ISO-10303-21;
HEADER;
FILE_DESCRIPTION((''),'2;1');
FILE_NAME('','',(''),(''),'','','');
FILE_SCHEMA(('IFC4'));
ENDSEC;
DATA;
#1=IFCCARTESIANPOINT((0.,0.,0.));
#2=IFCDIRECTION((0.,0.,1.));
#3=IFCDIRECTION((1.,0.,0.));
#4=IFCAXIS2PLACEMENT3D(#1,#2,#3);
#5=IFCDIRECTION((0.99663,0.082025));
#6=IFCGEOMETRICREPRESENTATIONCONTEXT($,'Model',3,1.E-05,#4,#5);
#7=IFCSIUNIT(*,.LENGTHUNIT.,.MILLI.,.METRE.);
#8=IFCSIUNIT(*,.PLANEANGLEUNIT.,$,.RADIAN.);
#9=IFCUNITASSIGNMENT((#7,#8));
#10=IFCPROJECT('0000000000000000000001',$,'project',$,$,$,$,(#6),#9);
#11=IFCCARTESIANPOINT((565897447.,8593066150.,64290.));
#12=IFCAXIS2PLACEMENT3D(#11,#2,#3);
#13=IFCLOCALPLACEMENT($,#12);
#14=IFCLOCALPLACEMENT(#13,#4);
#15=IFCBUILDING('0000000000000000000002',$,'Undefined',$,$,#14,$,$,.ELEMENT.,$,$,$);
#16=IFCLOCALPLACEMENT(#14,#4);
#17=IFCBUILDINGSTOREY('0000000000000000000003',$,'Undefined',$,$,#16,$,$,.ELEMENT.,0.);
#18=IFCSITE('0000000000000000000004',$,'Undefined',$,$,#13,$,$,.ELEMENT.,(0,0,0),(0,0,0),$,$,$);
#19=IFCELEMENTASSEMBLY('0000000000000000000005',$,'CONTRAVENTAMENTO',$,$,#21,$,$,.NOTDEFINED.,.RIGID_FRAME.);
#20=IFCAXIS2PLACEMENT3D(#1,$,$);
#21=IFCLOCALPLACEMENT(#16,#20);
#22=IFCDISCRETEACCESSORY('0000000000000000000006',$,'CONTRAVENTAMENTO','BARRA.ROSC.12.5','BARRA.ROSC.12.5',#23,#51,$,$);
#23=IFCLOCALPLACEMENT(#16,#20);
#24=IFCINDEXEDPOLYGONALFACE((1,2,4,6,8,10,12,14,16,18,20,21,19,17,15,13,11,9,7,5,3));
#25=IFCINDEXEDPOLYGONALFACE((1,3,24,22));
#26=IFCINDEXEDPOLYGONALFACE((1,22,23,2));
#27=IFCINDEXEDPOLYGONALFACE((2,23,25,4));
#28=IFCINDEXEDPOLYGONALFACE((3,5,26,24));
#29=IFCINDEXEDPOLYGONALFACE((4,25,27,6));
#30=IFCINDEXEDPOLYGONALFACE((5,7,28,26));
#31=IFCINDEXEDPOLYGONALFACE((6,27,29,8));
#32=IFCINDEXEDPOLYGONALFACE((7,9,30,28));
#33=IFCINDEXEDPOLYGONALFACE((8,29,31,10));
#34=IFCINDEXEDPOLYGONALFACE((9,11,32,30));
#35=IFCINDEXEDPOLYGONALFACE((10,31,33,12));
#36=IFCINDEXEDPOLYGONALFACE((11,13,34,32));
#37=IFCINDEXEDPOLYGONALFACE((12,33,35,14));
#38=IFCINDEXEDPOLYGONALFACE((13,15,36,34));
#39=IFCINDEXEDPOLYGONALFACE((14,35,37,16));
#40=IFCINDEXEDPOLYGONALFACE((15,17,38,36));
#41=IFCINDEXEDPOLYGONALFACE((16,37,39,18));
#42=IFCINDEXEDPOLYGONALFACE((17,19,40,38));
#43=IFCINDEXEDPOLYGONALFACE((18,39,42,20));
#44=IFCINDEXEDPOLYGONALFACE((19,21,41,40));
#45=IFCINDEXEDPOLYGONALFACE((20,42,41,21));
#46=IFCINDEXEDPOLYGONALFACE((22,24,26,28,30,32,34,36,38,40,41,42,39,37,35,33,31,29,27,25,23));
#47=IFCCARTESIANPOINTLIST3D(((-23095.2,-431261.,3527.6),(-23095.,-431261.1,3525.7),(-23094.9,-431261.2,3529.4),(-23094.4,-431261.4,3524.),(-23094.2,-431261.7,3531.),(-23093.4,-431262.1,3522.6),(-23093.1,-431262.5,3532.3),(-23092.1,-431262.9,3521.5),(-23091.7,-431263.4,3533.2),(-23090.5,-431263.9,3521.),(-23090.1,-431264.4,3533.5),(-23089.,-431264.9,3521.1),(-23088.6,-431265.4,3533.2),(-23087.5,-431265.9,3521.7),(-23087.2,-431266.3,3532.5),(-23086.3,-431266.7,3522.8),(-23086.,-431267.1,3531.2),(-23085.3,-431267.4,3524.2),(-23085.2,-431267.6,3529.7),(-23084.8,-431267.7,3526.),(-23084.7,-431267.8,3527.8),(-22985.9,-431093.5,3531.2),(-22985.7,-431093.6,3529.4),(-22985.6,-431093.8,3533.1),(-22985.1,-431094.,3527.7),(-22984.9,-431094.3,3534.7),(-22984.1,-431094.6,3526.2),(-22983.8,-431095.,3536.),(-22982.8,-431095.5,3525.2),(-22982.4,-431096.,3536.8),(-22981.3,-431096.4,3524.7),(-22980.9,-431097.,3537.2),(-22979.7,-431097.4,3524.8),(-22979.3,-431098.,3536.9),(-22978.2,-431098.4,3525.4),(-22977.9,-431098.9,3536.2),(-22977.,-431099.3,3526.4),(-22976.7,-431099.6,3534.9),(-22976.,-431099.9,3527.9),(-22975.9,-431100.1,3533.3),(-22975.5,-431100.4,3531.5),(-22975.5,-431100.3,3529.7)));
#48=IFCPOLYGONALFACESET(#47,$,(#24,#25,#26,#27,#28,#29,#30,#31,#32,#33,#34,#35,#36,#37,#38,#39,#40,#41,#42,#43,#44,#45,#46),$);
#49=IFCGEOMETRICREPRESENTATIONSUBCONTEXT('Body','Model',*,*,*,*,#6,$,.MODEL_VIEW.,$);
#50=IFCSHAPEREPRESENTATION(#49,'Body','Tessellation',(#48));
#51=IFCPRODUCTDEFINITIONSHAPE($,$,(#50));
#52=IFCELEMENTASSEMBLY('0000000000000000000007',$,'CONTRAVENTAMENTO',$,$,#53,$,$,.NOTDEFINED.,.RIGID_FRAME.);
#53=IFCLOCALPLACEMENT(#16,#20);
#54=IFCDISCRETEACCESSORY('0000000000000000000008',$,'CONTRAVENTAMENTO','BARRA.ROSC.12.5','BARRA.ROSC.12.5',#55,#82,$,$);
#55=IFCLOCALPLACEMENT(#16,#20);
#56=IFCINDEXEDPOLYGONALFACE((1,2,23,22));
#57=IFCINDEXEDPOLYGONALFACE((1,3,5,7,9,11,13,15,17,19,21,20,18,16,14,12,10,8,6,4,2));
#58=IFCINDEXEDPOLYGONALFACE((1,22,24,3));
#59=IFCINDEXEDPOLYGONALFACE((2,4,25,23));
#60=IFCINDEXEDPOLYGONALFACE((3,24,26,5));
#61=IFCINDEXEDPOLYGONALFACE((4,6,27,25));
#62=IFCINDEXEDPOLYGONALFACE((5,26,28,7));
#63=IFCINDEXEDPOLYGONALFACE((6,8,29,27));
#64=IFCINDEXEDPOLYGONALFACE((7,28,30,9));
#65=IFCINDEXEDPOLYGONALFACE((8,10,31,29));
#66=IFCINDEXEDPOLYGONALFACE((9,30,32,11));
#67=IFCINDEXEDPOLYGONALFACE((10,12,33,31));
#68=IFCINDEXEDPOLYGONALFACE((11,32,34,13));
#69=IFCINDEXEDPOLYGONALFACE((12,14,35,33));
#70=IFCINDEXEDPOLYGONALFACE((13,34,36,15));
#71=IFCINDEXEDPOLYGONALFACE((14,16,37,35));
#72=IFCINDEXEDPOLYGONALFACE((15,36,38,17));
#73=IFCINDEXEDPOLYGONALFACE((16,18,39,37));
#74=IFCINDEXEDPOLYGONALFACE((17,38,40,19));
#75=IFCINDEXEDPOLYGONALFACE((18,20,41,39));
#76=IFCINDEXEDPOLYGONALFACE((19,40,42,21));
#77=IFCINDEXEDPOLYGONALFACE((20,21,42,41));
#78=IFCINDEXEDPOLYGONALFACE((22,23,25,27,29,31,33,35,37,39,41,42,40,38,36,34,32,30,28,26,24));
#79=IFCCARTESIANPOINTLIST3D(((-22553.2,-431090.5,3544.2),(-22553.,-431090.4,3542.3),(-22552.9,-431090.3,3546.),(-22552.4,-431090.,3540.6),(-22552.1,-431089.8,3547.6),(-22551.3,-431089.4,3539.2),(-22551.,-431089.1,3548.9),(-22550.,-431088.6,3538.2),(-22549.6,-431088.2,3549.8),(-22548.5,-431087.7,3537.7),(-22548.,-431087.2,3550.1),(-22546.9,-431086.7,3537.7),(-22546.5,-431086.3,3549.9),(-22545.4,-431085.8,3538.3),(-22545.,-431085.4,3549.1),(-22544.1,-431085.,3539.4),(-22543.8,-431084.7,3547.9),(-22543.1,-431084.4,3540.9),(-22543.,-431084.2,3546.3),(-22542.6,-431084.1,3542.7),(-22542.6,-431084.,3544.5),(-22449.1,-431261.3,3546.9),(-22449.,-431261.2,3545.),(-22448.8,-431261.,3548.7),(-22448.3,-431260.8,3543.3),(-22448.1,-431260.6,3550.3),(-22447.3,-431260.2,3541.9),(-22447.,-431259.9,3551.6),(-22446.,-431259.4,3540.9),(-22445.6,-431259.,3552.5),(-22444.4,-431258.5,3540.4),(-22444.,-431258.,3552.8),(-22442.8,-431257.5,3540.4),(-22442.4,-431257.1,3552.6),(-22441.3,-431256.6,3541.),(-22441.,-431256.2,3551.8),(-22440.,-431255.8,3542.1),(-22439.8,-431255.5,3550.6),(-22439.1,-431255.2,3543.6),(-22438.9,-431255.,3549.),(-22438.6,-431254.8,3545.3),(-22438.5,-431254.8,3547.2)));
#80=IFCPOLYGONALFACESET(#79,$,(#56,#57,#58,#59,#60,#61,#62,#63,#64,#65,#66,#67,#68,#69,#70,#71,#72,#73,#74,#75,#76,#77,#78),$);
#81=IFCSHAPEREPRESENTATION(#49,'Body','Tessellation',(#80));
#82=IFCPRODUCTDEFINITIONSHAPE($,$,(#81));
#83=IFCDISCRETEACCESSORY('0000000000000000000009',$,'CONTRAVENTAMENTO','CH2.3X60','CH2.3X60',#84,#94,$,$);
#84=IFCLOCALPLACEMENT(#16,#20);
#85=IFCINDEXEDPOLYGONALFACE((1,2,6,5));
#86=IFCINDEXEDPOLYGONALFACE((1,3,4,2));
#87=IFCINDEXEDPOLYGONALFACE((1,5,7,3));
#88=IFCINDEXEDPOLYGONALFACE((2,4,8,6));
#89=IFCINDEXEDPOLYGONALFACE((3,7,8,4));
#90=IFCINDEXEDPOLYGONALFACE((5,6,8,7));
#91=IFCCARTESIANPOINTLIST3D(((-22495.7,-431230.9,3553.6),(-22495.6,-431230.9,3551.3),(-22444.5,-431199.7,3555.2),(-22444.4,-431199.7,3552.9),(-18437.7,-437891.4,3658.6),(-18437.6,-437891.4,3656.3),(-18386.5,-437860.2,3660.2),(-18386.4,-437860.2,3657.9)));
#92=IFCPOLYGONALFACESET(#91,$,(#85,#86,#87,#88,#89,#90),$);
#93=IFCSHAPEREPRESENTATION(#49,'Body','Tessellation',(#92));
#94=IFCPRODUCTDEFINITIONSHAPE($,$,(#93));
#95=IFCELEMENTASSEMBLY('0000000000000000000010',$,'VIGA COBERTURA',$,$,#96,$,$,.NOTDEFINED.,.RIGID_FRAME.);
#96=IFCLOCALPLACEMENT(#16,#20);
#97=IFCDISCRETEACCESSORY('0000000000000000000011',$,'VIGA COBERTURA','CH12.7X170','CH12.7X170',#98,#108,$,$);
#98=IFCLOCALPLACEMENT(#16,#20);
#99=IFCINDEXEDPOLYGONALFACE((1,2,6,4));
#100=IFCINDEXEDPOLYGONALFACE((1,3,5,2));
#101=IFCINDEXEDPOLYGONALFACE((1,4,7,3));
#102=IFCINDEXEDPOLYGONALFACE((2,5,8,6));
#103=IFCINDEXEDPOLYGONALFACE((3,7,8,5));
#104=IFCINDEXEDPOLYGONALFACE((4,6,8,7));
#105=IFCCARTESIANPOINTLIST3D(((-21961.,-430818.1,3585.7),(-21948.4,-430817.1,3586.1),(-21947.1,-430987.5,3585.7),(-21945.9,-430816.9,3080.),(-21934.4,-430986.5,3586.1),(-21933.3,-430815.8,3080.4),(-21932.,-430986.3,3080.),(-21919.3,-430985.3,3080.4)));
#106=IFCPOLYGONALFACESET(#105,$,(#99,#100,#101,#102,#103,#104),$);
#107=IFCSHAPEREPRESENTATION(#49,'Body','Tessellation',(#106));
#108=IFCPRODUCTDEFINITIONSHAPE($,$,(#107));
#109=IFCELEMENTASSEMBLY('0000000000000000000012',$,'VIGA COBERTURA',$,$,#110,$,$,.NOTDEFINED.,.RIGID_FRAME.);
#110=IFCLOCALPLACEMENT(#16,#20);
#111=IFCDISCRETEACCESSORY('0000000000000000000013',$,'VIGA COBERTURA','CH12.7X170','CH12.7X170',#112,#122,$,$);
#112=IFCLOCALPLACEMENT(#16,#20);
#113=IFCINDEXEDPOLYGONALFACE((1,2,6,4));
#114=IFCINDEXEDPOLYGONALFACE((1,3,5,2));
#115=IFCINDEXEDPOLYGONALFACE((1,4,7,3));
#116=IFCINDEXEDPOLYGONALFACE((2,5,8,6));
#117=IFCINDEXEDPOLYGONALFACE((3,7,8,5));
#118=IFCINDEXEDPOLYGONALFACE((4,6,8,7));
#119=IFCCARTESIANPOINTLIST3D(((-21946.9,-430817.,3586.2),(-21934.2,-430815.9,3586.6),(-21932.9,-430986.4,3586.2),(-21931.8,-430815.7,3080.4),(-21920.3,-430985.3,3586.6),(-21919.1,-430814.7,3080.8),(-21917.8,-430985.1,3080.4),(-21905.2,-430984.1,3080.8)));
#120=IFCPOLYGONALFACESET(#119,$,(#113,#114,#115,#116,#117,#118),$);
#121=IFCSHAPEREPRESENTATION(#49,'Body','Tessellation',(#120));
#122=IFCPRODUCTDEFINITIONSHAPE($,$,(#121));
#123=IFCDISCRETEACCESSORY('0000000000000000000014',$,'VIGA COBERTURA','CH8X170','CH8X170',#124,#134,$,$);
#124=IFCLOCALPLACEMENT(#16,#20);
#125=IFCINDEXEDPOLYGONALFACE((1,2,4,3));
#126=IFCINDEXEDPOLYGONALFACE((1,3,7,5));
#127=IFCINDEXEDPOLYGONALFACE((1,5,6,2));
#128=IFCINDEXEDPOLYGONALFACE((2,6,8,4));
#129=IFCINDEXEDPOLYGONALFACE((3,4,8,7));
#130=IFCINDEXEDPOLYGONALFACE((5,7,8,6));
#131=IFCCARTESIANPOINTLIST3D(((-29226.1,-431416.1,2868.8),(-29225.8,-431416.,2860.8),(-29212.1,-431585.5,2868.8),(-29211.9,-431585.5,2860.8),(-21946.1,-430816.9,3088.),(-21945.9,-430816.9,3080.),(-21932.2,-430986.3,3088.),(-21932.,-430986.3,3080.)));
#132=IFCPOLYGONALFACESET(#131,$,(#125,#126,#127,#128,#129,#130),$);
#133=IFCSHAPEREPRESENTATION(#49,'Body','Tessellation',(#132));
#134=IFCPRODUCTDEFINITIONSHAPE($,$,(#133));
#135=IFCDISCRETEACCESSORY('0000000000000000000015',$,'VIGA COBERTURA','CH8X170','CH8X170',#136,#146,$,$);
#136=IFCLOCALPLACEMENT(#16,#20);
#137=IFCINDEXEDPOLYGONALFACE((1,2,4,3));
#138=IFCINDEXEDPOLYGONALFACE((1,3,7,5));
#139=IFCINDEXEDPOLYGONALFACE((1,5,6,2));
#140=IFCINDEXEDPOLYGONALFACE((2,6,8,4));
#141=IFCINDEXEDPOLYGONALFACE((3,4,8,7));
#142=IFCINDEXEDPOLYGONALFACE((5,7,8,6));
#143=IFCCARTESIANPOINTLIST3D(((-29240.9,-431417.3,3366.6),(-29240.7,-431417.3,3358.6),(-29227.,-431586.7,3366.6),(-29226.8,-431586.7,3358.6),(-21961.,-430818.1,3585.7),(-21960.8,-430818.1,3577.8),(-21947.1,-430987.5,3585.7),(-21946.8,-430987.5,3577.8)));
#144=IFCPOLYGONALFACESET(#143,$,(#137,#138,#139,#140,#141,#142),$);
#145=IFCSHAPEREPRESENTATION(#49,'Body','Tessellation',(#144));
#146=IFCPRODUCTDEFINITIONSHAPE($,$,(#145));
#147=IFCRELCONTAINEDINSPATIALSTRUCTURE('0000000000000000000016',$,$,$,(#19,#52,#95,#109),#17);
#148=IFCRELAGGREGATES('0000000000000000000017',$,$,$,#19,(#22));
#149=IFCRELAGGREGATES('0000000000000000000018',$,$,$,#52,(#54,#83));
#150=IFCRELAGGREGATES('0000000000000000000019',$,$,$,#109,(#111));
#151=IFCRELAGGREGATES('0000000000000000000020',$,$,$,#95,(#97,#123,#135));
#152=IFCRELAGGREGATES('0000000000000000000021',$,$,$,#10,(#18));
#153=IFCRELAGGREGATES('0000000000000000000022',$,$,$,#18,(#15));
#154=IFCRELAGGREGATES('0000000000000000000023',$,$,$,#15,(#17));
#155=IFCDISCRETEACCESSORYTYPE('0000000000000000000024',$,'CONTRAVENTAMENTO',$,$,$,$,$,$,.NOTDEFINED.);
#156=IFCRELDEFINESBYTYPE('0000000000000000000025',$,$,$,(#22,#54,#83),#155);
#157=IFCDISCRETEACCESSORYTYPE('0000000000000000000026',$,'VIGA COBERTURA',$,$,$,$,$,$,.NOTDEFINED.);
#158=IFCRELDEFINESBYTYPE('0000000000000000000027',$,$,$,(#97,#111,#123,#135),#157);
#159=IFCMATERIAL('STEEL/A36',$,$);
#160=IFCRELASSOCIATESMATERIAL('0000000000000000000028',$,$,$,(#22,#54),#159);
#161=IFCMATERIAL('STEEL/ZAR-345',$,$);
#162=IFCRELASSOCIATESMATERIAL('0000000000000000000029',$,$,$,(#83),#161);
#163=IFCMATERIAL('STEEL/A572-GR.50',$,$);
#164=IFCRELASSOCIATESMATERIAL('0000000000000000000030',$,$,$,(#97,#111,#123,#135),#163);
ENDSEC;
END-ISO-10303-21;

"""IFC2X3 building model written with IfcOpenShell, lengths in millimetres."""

from ifc_helpers import new_model, si_unit, direction, frame, origin_with_axes, origin_2d_with_axis, place, context, subcontext, project, spatial, polyline, rectangle, circle, outline, extrude, material, type_object, element, aggregate, save


model = new_model("IFC2X3")

# Units and contexts
model_context = context("Model", 3, precision=1e-05, world=origin_with_axes(), true_north=direction((0.99663, 0.082025)))
body_context = subcontext(model_context, "Body", "Model", "MODEL_VIEW")
ifc_project = project(units=[si_unit("LENGTHUNIT", "METRE", prefix="MILLI"), si_unit("PLANEANGLEUNIT", "RADIAN")], contexts=[model_context])

# Site, building, storey
site_placement = place(None, frame((565897447.0, 8593066150.0, 64290.0), z_axis=(0.0, 0.0, 1.0), x_axis=(1.0, 0.0, 0.0)))
site = spatial("IfcSite", under=ifc_project, at=site_placement, Name="Undefined", CompositionType="ELEMENT", RefLatitude=(0, 0, 0), RefLongitude=(0, 0, 0))
building_placement = place(site_placement, origin_with_axes())
building = spatial("IfcBuilding", under=site, at=building_placement, Name="Undefined", CompositionType="ELEMENT")
storey_placement = place(building_placement, origin_with_axes())
storey = spatial("IfcBuildingStorey", under=building, at=storey_placement, Name="Undefined", CompositionType="ELEMENT", Elevation=0.0)

# Shared definitions
ifc_material_1 = material(Name="STEEL/A36")

# Element assembly, discrete accessory
assembly_1_placement = place(storey_placement, origin_with_axes())
assembly_1 = element("IfcElementAssembly", 1, at=assembly_1_placement, inside=storey, Name="CONTRAVENTAMENTO", AssemblyPlace="NOTDEFINED", PredefinedType="RIGID_FRAME")
discrete_accessory_type_1 = type_object("IfcDiscreteAccessoryType", Name="CONTRAVENTAMENTO")
discrete_accessory_1_placement = place(assembly_1_placement, frame((-22980.7, -431096.9, 3530.9), z_axis=(0.836984, -0.546715, 0.02368), x_axis=(-0.546411, -0.837315, -0.018398)))
discrete_accessory_1 = element("IfcDiscreteAccessory", 2, at=discrete_accessory_1_placement, type_object=discrete_accessory_type_1, material=ifc_material_1, Name="CONTRAVENTAMENTO", Description="BARRA.ROSC.12.5", ObjectType="BARRA.ROSC.12.5", context=body_context, shape_type="SweptSolid", body=[
    extrude(circle(Radius=6.2, at=origin_2d_with_axis()), frame((200.0, 0.0, 0.0), z_axis=(-1.0, 0.0, 0.0), x_axis=(0.0, -1.0, 0.0)), (0.0, 0.0, 1.0), 200.0),
])
aggregate(assembly_1, [discrete_accessory_1])

# Element assembly, discrete accessories
assembly_2_placement = place(storey_placement, origin_with_axes())
assembly_2 = element("IfcElementAssembly", 3, at=assembly_2_placement, inside=storey, Name="CONTRAVENTAMENTO", AssemblyPlace="NOTDEFINED", PredefinedType="RIGID_FRAME")
discrete_accessory_2_placement = place(assembly_2_placement, frame((-22547.9, -431087.2, 3543.9), z_axis=(0.853486, 0.520426, 0.026799), x_axis=(0.520257, -0.853903, 0.013454)))
discrete_accessory_2 = element("IfcDiscreteAccessory", 4, at=discrete_accessory_2_placement, type_object=discrete_accessory_type_1, material=ifc_material_1, Name="CONTRAVENTAMENTO", Description="BARRA.ROSC.12.5", ObjectType="BARRA.ROSC.12.5", context=body_context, shape_type="SweptSolid", body=[
    extrude(circle(Radius=6.2, at=origin_2d_with_axis()), frame((200.0, 0.0, 0.0), z_axis=(-1.0, 0.0, 0.0), x_axis=(0.0, -1.0, 0.0)), (0.0, 0.0, 1.0), 200.0),
])
ifc_material_2 = material(Name="STEEL/ZAR-345")
discrete_accessory_3_placement = place(assembly_2_placement, frame((-22470.0, -431215.3, 3553.3), z_axis=(-0.029885, -0.00246, 0.99955), x_axis=(0.520257, -0.853903, 0.013454)))
discrete_accessory_3 = element("IfcDiscreteAccessory", 5, at=discrete_accessory_3_placement, type_object=discrete_accessory_type_1, material=ifc_material_2, Name="CONTRAVENTAMENTO", Description="CH2.3X60", ObjectType="CH2.3X60", context=body_context, shape_type="SweptSolid", body=[
    extrude(outline(polyline([(0.0, 30.0), (7800.0, 30.0), (7800.0, -30.0), (0.0, -30.0), (0.0, 30.0)])), frame((0.0, 0.0, -1.1), z_axis=(0.0, 0.0, 1.0), x_axis=(1.0, 0.0, 0.0)), (0.0, 0.0, 1.0), 2.3),
])
aggregate(assembly_2, [discrete_accessory_2, discrete_accessory_3])

# Element assemblies, discrete accessories
assembly_3_placement = place(storey_placement, origin_with_axes())
assembly_3 = element("IfcElementAssembly", 6, at=assembly_3_placement, inside=storey, Name="VIGA COBERTURA", AssemblyPlace="NOTDEFINED", PredefinedType="RIGID_FRAME")
ifc_material_3 = material(Name="STEEL/A572-GR.50")
discrete_accessory_type_2 = type_object("IfcDiscreteAccessoryType", Name="VIGA COBERTURA")
discrete_accessory_4_placement = place(assembly_3_placement, frame((-21947.7, -430902.3, 3585.9), z_axis=(0.082025, -0.99663, 0.0), x_axis=(0.029885, 0.00246, -0.99955)))
discrete_accessory_4 = element("IfcDiscreteAccessory", 7, at=discrete_accessory_4_placement, type_object=discrete_accessory_type_2, material=ifc_material_3, Name="VIGA COBERTURA", Description="CH12.7X170", ObjectType="CH12.7X170", context=body_context, shape_type="SweptSolid", body=[
    extrude(rectangle(XDim=12.7, YDim=170.0, at=origin_2d_with_axis()), frame((506.0, 0.0, 0.0), z_axis=(-1.0, 0.0, 0.0), x_axis=(0.0, -1.0, 0.0)), (0.0, 0.0, 1.0), 506.0),
])
assembly_4_placement = place(storey_placement, origin_with_axes())
assembly_4 = element("IfcElementAssembly", 8, at=assembly_4_placement, inside=storey, Name="VIGA COBERTURA", AssemblyPlace="NOTDEFINED", PredefinedType="RIGID_FRAME")
discrete_accessory_5_placement = place(assembly_4_placement, frame((-21933.6, -430901.1, 3586.4), z_axis=(0.082025, -0.99663, 0.0), x_axis=(0.029885, 0.00246, -0.99955)))
discrete_accessory_5 = element("IfcDiscreteAccessory", 9, at=discrete_accessory_5_placement, type_object=discrete_accessory_type_2, material=ifc_material_3, Name="VIGA COBERTURA", Description="CH12.7X170", ObjectType="CH12.7X170", context=body_context, shape_type="SweptSolid", body=[
    extrude(rectangle(XDim=12.7, YDim=170.0, at=origin_2d_with_axis()), frame((506.0, 0.0, 0.0), z_axis=(-1.0, 0.0, 0.0), x_axis=(0.0, -1.0, 0.0)), (0.0, 0.0, 1.0), 506.0),
])

# Discrete accessories
discrete_accessory_6_placement = place(assembly_3_placement, frame((-21939.1, -430901.6, 3084.0), z_axis=(0.029885, 0.00246, -0.99955), x_axis=(-0.996182, -0.081989, -0.029987)))
discrete_accessory_6 = element("IfcDiscreteAccessory", 10, at=discrete_accessory_6_placement, type_object=discrete_accessory_type_2, material=ifc_material_3, Name="VIGA COBERTURA", Description="CH8X170", ObjectType="CH8X170", context=body_context, shape_type="SweptSolid", body=[
    extrude(outline(polyline([(7307.8, 85.0), (7307.8, -85.0), (0.0, -85.0), (0.0, 85.0), (7307.8, 85.0)])), frame((0.0, 0.0, -4.0), z_axis=(0.0, 0.0, 1.0), x_axis=(1.0, 0.0, 0.0)), (0.0, 0.0, 1.0), 8.0),
])
aggregate(assembly_4, [discrete_accessory_5])
discrete_accessory_7_placement = place(assembly_3_placement, frame((-21953.9, -430902.8, 3581.7), z_axis=(0.029885, 0.00246, -0.99955), x_axis=(-0.996182, -0.081989, -0.029987)))
discrete_accessory_7 = element("IfcDiscreteAccessory", 11, at=discrete_accessory_7_placement, type_object=discrete_accessory_type_2, material=ifc_material_3, Name="VIGA COBERTURA", Description="CH8X170", ObjectType="CH8X170", context=body_context, shape_type="SweptSolid", body=[
    extrude(outline(polyline([(7307.8, 85.0), (7307.8, -85.0), (0.0, -85.0), (0.0, 85.0), (7307.8, 85.0)])), frame((0.0, 0.0, -4.0), z_axis=(0.0, 0.0, 1.0), x_axis=(1.0, 0.0, 0.0)), (0.0, 0.0, 1.0), 8.0),
])
aggregate(assembly_3, [discrete_accessory_4, discrete_accessory_6, discrete_accessory_7])

save(model, "model.ifc")
